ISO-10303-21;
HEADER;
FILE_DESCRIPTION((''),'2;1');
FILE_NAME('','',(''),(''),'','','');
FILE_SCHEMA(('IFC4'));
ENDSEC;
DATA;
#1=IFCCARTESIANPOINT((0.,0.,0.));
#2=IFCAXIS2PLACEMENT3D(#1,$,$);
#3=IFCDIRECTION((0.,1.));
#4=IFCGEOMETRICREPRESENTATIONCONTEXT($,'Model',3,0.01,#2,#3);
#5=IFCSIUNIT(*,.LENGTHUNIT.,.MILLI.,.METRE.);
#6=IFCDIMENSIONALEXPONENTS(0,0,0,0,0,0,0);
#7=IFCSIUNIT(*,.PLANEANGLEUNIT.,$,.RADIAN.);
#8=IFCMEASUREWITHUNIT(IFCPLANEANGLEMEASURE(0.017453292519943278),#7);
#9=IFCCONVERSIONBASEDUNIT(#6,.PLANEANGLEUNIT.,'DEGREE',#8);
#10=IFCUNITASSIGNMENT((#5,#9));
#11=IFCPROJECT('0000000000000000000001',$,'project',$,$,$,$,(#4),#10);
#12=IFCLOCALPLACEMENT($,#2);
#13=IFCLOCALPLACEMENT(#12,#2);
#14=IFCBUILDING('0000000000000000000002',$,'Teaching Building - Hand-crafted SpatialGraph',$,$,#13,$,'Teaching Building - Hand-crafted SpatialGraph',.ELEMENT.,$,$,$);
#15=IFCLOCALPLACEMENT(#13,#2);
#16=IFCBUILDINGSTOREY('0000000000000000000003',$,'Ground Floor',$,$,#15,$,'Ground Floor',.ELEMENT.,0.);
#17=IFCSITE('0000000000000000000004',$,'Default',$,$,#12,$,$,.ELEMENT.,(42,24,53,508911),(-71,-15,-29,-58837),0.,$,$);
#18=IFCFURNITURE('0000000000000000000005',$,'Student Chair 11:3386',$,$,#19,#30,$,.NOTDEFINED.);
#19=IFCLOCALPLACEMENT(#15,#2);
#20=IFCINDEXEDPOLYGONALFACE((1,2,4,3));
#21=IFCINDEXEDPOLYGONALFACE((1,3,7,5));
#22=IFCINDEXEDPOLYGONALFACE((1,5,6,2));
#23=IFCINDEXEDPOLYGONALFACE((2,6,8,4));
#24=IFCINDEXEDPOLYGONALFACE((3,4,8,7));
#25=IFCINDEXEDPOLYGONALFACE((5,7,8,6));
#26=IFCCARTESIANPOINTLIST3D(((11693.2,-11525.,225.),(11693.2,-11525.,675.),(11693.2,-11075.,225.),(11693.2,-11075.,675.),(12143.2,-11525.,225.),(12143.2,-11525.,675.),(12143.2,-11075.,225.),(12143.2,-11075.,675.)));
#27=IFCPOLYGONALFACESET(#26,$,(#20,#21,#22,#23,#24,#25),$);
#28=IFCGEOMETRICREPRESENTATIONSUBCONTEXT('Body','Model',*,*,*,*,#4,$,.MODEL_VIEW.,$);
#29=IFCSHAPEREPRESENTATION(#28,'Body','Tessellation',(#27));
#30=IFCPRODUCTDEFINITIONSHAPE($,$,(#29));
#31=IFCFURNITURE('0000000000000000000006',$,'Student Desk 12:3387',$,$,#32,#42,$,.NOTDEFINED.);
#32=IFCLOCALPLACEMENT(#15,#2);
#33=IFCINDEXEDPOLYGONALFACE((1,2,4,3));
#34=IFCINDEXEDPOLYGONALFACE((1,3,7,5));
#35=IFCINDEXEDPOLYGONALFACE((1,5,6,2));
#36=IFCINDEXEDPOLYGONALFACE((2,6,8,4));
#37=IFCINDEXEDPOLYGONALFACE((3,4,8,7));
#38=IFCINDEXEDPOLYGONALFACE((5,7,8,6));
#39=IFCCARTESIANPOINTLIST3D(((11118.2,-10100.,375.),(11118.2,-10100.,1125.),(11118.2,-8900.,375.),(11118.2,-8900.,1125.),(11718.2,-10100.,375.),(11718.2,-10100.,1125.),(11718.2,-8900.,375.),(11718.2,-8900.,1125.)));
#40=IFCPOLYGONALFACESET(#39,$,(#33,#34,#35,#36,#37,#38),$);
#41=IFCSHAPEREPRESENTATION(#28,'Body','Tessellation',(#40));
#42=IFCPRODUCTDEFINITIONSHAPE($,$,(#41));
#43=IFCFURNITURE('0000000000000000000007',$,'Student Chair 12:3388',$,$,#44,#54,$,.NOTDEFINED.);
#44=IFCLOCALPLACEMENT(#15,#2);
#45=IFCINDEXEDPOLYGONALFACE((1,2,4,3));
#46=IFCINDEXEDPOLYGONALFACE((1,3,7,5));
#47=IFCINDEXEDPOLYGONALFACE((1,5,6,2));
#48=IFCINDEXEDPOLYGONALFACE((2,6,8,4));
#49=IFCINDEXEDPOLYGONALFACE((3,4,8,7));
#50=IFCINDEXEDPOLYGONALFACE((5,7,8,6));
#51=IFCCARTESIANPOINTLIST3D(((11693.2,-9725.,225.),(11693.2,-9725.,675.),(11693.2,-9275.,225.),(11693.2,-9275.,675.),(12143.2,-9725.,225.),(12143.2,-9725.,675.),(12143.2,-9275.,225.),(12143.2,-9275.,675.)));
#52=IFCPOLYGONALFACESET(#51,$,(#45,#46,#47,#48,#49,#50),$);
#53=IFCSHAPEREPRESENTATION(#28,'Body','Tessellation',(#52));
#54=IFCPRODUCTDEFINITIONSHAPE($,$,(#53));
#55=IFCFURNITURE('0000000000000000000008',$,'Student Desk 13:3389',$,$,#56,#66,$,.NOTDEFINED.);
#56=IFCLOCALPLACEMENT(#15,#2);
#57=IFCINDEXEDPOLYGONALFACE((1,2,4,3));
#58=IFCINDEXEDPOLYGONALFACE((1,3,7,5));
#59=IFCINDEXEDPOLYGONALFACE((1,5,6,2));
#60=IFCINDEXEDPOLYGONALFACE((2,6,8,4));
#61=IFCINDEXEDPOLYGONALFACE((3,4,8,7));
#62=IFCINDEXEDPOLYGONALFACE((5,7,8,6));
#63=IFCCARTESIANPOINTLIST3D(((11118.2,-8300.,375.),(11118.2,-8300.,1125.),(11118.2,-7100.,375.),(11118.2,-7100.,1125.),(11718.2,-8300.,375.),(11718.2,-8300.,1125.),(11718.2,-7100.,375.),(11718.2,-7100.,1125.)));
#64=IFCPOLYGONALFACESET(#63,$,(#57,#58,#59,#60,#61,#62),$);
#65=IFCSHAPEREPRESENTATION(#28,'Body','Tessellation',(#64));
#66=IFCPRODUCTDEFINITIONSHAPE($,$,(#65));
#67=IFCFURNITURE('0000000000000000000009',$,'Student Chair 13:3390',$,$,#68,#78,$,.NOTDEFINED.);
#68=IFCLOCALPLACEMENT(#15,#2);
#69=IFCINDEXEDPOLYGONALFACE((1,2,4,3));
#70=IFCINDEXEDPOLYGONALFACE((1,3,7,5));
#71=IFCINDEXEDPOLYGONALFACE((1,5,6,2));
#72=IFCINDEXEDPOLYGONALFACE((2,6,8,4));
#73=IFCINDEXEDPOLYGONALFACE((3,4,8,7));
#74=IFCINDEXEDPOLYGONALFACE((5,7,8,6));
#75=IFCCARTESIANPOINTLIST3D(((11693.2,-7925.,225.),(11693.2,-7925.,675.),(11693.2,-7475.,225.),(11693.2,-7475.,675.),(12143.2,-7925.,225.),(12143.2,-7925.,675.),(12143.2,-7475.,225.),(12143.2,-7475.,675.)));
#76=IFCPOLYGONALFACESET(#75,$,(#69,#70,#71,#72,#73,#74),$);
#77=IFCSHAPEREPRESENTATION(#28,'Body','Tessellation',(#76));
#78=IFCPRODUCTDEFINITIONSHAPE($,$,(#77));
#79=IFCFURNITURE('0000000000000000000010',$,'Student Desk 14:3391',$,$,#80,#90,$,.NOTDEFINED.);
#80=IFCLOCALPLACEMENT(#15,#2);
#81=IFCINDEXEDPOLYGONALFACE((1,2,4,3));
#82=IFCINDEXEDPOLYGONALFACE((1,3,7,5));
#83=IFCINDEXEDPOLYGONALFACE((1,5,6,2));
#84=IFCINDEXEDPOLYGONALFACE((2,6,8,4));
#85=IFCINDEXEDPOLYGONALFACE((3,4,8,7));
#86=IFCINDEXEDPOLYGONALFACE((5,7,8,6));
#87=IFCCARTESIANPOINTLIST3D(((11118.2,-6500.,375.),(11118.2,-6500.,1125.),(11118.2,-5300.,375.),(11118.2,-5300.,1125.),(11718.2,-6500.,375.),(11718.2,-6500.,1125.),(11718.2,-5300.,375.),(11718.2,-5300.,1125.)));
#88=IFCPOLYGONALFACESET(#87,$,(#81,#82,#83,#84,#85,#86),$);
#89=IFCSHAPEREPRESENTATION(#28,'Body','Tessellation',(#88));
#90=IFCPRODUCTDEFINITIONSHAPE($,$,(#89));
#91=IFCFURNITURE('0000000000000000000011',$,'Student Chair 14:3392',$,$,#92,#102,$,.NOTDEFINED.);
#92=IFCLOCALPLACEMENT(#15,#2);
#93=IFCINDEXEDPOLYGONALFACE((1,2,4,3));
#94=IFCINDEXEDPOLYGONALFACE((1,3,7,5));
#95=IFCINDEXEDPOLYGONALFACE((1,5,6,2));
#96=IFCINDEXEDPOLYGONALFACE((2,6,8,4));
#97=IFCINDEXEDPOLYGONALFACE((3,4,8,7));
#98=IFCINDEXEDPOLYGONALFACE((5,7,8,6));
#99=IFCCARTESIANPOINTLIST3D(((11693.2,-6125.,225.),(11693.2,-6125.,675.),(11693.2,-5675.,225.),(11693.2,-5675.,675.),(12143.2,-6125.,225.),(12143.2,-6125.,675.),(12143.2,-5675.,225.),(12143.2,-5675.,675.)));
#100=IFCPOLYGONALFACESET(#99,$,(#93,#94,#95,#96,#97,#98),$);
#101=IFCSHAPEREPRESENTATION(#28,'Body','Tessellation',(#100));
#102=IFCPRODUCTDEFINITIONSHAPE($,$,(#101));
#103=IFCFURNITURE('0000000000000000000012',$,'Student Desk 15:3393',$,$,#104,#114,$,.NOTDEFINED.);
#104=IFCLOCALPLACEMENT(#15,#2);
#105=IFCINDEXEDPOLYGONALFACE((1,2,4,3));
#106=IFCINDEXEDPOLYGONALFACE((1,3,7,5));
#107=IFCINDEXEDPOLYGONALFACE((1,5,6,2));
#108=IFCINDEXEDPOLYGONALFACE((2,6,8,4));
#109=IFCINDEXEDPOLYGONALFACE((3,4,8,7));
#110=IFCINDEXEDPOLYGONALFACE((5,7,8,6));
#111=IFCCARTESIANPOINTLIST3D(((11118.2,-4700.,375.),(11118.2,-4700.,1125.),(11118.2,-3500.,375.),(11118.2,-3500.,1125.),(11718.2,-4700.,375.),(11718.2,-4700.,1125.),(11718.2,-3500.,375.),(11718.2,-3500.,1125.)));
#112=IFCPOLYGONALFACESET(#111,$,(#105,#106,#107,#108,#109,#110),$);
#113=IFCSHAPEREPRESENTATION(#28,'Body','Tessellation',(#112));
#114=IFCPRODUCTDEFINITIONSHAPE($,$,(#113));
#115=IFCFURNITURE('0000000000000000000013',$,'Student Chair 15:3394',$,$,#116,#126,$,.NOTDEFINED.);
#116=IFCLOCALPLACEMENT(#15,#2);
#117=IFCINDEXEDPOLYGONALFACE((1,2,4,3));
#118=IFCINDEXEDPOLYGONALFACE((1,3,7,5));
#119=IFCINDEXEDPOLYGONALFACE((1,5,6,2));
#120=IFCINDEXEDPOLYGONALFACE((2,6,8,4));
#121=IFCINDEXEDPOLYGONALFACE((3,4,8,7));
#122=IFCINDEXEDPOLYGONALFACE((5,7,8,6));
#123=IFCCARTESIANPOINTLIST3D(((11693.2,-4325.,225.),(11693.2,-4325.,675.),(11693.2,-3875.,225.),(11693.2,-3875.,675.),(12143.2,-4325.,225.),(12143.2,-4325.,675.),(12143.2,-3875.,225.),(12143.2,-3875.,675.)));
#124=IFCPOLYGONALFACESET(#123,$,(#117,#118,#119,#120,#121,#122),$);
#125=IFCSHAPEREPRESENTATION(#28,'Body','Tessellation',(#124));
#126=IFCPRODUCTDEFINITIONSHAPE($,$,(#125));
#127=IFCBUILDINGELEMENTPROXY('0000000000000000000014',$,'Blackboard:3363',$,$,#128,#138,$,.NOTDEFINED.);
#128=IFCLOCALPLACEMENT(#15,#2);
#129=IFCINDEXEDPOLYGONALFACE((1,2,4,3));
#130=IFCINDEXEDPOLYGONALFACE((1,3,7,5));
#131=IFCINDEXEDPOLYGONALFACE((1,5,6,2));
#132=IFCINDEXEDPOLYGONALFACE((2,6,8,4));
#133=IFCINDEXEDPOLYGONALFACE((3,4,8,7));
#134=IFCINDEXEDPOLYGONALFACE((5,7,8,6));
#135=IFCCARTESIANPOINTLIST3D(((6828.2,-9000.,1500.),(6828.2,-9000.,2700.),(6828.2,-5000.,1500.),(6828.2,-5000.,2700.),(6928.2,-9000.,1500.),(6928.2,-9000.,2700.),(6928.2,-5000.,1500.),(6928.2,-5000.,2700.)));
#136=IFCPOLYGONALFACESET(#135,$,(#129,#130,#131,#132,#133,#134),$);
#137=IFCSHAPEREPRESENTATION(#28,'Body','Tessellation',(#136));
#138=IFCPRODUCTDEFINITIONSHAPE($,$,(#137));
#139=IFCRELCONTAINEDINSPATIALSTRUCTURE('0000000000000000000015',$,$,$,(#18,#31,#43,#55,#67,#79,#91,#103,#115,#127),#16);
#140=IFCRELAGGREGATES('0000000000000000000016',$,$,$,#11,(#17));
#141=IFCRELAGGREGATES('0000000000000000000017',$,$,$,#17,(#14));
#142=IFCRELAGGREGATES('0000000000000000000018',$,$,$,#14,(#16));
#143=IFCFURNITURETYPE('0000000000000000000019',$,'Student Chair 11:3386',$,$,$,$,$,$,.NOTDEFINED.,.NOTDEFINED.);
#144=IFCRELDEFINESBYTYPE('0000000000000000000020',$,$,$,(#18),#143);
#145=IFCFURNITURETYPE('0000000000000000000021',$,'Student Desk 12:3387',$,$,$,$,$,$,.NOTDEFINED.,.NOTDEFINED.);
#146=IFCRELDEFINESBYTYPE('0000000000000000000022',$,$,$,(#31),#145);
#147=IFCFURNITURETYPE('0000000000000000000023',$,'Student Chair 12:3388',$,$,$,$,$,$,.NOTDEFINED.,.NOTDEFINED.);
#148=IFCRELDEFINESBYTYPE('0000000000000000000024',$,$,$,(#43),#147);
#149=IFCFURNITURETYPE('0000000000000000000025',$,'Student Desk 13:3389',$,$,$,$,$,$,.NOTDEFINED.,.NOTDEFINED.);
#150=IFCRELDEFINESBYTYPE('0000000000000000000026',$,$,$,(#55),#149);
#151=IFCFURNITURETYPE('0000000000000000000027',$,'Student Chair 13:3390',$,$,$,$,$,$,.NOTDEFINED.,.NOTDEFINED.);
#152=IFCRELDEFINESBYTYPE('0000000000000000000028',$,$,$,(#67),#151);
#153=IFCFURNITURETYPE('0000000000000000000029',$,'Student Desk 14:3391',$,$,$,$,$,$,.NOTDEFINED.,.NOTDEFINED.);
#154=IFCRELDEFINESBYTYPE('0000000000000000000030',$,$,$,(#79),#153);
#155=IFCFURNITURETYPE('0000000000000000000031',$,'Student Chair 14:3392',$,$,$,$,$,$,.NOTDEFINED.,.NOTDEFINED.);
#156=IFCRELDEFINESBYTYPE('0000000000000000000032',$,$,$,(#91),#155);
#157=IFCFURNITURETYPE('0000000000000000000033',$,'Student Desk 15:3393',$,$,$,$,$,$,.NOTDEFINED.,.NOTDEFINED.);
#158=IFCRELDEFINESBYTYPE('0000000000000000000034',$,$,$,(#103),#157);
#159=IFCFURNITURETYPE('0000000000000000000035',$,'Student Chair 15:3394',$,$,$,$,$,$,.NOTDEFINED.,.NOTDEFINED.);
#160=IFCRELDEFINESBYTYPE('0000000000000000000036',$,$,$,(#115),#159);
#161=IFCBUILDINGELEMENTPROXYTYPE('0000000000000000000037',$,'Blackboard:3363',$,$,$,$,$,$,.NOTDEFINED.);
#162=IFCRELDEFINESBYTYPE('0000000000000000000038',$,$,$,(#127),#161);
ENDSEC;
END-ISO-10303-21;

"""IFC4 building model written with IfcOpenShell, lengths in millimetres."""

from ifc_helpers import new_model, entity, si_unit, converted_unit, direction, frame, frame_2d, origin, origin_2d_with_axis, place, context, subcontext, project, spatial, rectangle, extrude, type_object, element, save


model = new_model("IFC4")

# Units and contexts
model_context = context("Model", 3, precision=0.01, world=origin(), true_north=direction((0.0, 1.0)))
body_context = subcontext(model_context, "Body", "Model", "MODEL_VIEW")
ifc_project = project(units=[si_unit("LENGTHUNIT", "METRE", prefix="MILLI"), converted_unit("PLANEANGLEUNIT", "DEGREE", entity("IfcPlaneAngleMeasure", 0.017453292519943278), si_unit("PLANEANGLEUNIT", "RADIAN"), dimensions=[0, 0, 0, 0, 0, 0, 0])], contexts=[model_context])

# Site, building, storey
site_placement = place(None, origin())
site = spatial("IfcSite", under=ifc_project, at=site_placement, Name="Default", CompositionType="ELEMENT", RefLatitude=(42, 24, 53, 508911), RefLongitude=(-71, -15, -29, -58837), RefElevation=0.0)
building_placement = place(site_placement, origin())
building = spatial("IfcBuilding", under=site, at=building_placement, Name="Teaching Building - Hand-crafted SpatialGraph", LongName="Teaching Building - Hand-crafted SpatialGraph", CompositionType="ELEMENT")
storey_placement = place(building_placement, origin())
storey = spatial("IfcBuildingStorey", under=building, at=storey_placement, Name="Ground Floor", LongName="Ground Floor", CompositionType="ELEMENT", Elevation=0.0)

# Furniture
furniture_type_1 = type_object("IfcFurnitureType", Name="Student Chair 11:3386", PredefinedType="NOTDEFINED")
furniture_1_placement = place(storey_placement, origin())
element("IfcFurniture", 1, at=furniture_1_placement, inside=storey, type_object=furniture_type_1, Name="Student Chair 11:3386", PredefinedType="NOTDEFINED", context=body_context, shape_type="SweptSolid", body=[
    extrude(rectangle(XDim=450.0, YDim=450.0, at=origin_2d_with_axis()), frame((11918.2, -11300.0, 225.0)), (0.0, 0.0, 1.0), 450.0),
])
furniture_type_2 = type_object("IfcFurnitureType", Name="Student Desk 12:3387", PredefinedType="NOTDEFINED")
furniture_2_placement = place(storey_placement, origin())
element("IfcFurniture", 2, at=furniture_2_placement, inside=storey, type_object=furniture_type_2, Name="Student Desk 12:3387", PredefinedType="NOTDEFINED", context=body_context, shape_type="SweptSolid", body=[
    extrude(rectangle(XDim=1200.0, YDim=600.0, at=origin_2d_with_axis()), frame((11418.2, -9500.0, 375.0), z_axis=(0.0, 0.0, 1.0), x_axis=(0.0, 1.0, 0.0)), (0.0, 0.0, 1.0), 750.0),
])
furniture_type_3 = type_object("IfcFurnitureType", Name="Student Chair 12:3388", PredefinedType="NOTDEFINED")
furniture_3_placement = place(storey_placement, origin())
element("IfcFurniture", 3, at=furniture_3_placement, inside=storey, type_object=furniture_type_3, Name="Student Chair 12:3388", PredefinedType="NOTDEFINED", context=body_context, shape_type="SweptSolid", body=[
    extrude(rectangle(XDim=450.0, YDim=450.0, at=origin_2d_with_axis()), frame((11918.2, -9500.0, 225.0)), (0.0, 0.0, 1.0), 450.0),
])
furniture_type_4 = type_object("IfcFurnitureType", Name="Student Desk 13:3389", PredefinedType="NOTDEFINED")
furniture_4_placement = place(storey_placement, origin())
element("IfcFurniture", 4, at=furniture_4_placement, inside=storey, type_object=furniture_type_4, Name="Student Desk 13:3389", PredefinedType="NOTDEFINED", context=body_context, shape_type="SweptSolid", body=[
    extrude(rectangle(XDim=1200.0, YDim=600.0, at=origin_2d_with_axis()), frame((11418.2, -7700.0, 375.0), z_axis=(0.0, 0.0, 1.0), x_axis=(0.0, 1.0, 0.0)), (0.0, 0.0, 1.0), 750.0),
])
furniture_type_5 = type_object("IfcFurnitureType", Name="Student Chair 13:3390", PredefinedType="NOTDEFINED")
furniture_5_placement = place(storey_placement, origin())
element("IfcFurniture", 5, at=furniture_5_placement, inside=storey, type_object=furniture_type_5, Name="Student Chair 13:3390", PredefinedType="NOTDEFINED", context=body_context, shape_type="SweptSolid", body=[
    extrude(rectangle(XDim=450.0, YDim=450.0, at=frame_2d((0.0, 0.0), x_axis=(1.0, 0.0))), frame((11918.2, -7700.0, 225.0)), (0.0, 0.0, 1.0), 450.0),
])
furniture_type_6 = type_object("IfcFurnitureType", Name="Student Desk 14:3391", PredefinedType="NOTDEFINED")
furniture_6_placement = place(storey_placement, origin())
element("IfcFurniture", 6, at=furniture_6_placement, inside=storey, type_object=furniture_type_6, Name="Student Desk 14:3391", PredefinedType="NOTDEFINED", context=body_context, shape_type="SweptSolid", body=[
    extrude(rectangle(XDim=1200.0, YDim=600.0, at=origin_2d_with_axis()), frame((11418.2, -5900.0, 375.0), z_axis=(0.0, 0.0, 1.0), x_axis=(0.0, 1.0, 0.0)), (0.0, 0.0, 1.0), 750.0),
])
furniture_type_7 = type_object("IfcFurnitureType", Name="Student Chair 14:3392", PredefinedType="NOTDEFINED")
furniture_7_placement = place(storey_placement, origin())
element("IfcFurniture", 7, at=furniture_7_placement, inside=storey, type_object=furniture_type_7, Name="Student Chair 14:3392", PredefinedType="NOTDEFINED", context=body_context, shape_type="SweptSolid", body=[
    extrude(rectangle(XDim=450.0, YDim=450.0, at=origin_2d_with_axis()), frame((11918.2, -5900.0, 225.0)), (0.0, 0.0, 1.0), 450.0),
])
furniture_type_8 = type_object("IfcFurnitureType", Name="Student Desk 15:3393", PredefinedType="NOTDEFINED")
furniture_8_placement = place(storey_placement, origin())
element("IfcFurniture", 8, at=furniture_8_placement, inside=storey, type_object=furniture_type_8, Name="Student Desk 15:3393", PredefinedType="NOTDEFINED", context=body_context, shape_type="SweptSolid", body=[
    extrude(rectangle(XDim=1200.0, YDim=600.0, at=origin_2d_with_axis()), frame((11418.2, -4100.0, 375.0), z_axis=(0.0, 0.0, 1.0), x_axis=(0.0, 1.0, 0.0)), (0.0, 0.0, 1.0), 750.0),
])
furniture_type_9 = type_object("IfcFurnitureType", Name="Student Chair 15:3394", PredefinedType="NOTDEFINED")
furniture_9_placement = place(storey_placement, origin())
element("IfcFurniture", 9, at=furniture_9_placement, inside=storey, type_object=furniture_type_9, Name="Student Chair 15:3394", PredefinedType="NOTDEFINED", context=body_context, shape_type="SweptSolid", body=[
    extrude(rectangle(XDim=450.0, YDim=450.0, at=origin_2d_with_axis()), frame((11918.2, -4100.0, 225.0)), (0.0, 0.0, 1.0), 450.0),
])

# Building element proxy
building_element_proxy_type = type_object("IfcBuildingElementProxyType", Name="Blackboard:3363", PredefinedType="NOTDEFINED")
proxy_placement = place(storey_placement, origin())
element("IfcBuildingElementProxy", 10, at=proxy_placement, inside=storey, type_object=building_element_proxy_type, Name="Blackboard:3363", PredefinedType="NOTDEFINED", context=body_context, shape_type="SweptSolid", body=[
    extrude(rectangle(XDim=100.0, YDim=4000.0, at=origin_2d_with_axis()), frame((6878.2, -7000.0, 1500.0)), (0.0, 0.0, 1.0), 1200.0),
])

save(model, "model.ifc")
